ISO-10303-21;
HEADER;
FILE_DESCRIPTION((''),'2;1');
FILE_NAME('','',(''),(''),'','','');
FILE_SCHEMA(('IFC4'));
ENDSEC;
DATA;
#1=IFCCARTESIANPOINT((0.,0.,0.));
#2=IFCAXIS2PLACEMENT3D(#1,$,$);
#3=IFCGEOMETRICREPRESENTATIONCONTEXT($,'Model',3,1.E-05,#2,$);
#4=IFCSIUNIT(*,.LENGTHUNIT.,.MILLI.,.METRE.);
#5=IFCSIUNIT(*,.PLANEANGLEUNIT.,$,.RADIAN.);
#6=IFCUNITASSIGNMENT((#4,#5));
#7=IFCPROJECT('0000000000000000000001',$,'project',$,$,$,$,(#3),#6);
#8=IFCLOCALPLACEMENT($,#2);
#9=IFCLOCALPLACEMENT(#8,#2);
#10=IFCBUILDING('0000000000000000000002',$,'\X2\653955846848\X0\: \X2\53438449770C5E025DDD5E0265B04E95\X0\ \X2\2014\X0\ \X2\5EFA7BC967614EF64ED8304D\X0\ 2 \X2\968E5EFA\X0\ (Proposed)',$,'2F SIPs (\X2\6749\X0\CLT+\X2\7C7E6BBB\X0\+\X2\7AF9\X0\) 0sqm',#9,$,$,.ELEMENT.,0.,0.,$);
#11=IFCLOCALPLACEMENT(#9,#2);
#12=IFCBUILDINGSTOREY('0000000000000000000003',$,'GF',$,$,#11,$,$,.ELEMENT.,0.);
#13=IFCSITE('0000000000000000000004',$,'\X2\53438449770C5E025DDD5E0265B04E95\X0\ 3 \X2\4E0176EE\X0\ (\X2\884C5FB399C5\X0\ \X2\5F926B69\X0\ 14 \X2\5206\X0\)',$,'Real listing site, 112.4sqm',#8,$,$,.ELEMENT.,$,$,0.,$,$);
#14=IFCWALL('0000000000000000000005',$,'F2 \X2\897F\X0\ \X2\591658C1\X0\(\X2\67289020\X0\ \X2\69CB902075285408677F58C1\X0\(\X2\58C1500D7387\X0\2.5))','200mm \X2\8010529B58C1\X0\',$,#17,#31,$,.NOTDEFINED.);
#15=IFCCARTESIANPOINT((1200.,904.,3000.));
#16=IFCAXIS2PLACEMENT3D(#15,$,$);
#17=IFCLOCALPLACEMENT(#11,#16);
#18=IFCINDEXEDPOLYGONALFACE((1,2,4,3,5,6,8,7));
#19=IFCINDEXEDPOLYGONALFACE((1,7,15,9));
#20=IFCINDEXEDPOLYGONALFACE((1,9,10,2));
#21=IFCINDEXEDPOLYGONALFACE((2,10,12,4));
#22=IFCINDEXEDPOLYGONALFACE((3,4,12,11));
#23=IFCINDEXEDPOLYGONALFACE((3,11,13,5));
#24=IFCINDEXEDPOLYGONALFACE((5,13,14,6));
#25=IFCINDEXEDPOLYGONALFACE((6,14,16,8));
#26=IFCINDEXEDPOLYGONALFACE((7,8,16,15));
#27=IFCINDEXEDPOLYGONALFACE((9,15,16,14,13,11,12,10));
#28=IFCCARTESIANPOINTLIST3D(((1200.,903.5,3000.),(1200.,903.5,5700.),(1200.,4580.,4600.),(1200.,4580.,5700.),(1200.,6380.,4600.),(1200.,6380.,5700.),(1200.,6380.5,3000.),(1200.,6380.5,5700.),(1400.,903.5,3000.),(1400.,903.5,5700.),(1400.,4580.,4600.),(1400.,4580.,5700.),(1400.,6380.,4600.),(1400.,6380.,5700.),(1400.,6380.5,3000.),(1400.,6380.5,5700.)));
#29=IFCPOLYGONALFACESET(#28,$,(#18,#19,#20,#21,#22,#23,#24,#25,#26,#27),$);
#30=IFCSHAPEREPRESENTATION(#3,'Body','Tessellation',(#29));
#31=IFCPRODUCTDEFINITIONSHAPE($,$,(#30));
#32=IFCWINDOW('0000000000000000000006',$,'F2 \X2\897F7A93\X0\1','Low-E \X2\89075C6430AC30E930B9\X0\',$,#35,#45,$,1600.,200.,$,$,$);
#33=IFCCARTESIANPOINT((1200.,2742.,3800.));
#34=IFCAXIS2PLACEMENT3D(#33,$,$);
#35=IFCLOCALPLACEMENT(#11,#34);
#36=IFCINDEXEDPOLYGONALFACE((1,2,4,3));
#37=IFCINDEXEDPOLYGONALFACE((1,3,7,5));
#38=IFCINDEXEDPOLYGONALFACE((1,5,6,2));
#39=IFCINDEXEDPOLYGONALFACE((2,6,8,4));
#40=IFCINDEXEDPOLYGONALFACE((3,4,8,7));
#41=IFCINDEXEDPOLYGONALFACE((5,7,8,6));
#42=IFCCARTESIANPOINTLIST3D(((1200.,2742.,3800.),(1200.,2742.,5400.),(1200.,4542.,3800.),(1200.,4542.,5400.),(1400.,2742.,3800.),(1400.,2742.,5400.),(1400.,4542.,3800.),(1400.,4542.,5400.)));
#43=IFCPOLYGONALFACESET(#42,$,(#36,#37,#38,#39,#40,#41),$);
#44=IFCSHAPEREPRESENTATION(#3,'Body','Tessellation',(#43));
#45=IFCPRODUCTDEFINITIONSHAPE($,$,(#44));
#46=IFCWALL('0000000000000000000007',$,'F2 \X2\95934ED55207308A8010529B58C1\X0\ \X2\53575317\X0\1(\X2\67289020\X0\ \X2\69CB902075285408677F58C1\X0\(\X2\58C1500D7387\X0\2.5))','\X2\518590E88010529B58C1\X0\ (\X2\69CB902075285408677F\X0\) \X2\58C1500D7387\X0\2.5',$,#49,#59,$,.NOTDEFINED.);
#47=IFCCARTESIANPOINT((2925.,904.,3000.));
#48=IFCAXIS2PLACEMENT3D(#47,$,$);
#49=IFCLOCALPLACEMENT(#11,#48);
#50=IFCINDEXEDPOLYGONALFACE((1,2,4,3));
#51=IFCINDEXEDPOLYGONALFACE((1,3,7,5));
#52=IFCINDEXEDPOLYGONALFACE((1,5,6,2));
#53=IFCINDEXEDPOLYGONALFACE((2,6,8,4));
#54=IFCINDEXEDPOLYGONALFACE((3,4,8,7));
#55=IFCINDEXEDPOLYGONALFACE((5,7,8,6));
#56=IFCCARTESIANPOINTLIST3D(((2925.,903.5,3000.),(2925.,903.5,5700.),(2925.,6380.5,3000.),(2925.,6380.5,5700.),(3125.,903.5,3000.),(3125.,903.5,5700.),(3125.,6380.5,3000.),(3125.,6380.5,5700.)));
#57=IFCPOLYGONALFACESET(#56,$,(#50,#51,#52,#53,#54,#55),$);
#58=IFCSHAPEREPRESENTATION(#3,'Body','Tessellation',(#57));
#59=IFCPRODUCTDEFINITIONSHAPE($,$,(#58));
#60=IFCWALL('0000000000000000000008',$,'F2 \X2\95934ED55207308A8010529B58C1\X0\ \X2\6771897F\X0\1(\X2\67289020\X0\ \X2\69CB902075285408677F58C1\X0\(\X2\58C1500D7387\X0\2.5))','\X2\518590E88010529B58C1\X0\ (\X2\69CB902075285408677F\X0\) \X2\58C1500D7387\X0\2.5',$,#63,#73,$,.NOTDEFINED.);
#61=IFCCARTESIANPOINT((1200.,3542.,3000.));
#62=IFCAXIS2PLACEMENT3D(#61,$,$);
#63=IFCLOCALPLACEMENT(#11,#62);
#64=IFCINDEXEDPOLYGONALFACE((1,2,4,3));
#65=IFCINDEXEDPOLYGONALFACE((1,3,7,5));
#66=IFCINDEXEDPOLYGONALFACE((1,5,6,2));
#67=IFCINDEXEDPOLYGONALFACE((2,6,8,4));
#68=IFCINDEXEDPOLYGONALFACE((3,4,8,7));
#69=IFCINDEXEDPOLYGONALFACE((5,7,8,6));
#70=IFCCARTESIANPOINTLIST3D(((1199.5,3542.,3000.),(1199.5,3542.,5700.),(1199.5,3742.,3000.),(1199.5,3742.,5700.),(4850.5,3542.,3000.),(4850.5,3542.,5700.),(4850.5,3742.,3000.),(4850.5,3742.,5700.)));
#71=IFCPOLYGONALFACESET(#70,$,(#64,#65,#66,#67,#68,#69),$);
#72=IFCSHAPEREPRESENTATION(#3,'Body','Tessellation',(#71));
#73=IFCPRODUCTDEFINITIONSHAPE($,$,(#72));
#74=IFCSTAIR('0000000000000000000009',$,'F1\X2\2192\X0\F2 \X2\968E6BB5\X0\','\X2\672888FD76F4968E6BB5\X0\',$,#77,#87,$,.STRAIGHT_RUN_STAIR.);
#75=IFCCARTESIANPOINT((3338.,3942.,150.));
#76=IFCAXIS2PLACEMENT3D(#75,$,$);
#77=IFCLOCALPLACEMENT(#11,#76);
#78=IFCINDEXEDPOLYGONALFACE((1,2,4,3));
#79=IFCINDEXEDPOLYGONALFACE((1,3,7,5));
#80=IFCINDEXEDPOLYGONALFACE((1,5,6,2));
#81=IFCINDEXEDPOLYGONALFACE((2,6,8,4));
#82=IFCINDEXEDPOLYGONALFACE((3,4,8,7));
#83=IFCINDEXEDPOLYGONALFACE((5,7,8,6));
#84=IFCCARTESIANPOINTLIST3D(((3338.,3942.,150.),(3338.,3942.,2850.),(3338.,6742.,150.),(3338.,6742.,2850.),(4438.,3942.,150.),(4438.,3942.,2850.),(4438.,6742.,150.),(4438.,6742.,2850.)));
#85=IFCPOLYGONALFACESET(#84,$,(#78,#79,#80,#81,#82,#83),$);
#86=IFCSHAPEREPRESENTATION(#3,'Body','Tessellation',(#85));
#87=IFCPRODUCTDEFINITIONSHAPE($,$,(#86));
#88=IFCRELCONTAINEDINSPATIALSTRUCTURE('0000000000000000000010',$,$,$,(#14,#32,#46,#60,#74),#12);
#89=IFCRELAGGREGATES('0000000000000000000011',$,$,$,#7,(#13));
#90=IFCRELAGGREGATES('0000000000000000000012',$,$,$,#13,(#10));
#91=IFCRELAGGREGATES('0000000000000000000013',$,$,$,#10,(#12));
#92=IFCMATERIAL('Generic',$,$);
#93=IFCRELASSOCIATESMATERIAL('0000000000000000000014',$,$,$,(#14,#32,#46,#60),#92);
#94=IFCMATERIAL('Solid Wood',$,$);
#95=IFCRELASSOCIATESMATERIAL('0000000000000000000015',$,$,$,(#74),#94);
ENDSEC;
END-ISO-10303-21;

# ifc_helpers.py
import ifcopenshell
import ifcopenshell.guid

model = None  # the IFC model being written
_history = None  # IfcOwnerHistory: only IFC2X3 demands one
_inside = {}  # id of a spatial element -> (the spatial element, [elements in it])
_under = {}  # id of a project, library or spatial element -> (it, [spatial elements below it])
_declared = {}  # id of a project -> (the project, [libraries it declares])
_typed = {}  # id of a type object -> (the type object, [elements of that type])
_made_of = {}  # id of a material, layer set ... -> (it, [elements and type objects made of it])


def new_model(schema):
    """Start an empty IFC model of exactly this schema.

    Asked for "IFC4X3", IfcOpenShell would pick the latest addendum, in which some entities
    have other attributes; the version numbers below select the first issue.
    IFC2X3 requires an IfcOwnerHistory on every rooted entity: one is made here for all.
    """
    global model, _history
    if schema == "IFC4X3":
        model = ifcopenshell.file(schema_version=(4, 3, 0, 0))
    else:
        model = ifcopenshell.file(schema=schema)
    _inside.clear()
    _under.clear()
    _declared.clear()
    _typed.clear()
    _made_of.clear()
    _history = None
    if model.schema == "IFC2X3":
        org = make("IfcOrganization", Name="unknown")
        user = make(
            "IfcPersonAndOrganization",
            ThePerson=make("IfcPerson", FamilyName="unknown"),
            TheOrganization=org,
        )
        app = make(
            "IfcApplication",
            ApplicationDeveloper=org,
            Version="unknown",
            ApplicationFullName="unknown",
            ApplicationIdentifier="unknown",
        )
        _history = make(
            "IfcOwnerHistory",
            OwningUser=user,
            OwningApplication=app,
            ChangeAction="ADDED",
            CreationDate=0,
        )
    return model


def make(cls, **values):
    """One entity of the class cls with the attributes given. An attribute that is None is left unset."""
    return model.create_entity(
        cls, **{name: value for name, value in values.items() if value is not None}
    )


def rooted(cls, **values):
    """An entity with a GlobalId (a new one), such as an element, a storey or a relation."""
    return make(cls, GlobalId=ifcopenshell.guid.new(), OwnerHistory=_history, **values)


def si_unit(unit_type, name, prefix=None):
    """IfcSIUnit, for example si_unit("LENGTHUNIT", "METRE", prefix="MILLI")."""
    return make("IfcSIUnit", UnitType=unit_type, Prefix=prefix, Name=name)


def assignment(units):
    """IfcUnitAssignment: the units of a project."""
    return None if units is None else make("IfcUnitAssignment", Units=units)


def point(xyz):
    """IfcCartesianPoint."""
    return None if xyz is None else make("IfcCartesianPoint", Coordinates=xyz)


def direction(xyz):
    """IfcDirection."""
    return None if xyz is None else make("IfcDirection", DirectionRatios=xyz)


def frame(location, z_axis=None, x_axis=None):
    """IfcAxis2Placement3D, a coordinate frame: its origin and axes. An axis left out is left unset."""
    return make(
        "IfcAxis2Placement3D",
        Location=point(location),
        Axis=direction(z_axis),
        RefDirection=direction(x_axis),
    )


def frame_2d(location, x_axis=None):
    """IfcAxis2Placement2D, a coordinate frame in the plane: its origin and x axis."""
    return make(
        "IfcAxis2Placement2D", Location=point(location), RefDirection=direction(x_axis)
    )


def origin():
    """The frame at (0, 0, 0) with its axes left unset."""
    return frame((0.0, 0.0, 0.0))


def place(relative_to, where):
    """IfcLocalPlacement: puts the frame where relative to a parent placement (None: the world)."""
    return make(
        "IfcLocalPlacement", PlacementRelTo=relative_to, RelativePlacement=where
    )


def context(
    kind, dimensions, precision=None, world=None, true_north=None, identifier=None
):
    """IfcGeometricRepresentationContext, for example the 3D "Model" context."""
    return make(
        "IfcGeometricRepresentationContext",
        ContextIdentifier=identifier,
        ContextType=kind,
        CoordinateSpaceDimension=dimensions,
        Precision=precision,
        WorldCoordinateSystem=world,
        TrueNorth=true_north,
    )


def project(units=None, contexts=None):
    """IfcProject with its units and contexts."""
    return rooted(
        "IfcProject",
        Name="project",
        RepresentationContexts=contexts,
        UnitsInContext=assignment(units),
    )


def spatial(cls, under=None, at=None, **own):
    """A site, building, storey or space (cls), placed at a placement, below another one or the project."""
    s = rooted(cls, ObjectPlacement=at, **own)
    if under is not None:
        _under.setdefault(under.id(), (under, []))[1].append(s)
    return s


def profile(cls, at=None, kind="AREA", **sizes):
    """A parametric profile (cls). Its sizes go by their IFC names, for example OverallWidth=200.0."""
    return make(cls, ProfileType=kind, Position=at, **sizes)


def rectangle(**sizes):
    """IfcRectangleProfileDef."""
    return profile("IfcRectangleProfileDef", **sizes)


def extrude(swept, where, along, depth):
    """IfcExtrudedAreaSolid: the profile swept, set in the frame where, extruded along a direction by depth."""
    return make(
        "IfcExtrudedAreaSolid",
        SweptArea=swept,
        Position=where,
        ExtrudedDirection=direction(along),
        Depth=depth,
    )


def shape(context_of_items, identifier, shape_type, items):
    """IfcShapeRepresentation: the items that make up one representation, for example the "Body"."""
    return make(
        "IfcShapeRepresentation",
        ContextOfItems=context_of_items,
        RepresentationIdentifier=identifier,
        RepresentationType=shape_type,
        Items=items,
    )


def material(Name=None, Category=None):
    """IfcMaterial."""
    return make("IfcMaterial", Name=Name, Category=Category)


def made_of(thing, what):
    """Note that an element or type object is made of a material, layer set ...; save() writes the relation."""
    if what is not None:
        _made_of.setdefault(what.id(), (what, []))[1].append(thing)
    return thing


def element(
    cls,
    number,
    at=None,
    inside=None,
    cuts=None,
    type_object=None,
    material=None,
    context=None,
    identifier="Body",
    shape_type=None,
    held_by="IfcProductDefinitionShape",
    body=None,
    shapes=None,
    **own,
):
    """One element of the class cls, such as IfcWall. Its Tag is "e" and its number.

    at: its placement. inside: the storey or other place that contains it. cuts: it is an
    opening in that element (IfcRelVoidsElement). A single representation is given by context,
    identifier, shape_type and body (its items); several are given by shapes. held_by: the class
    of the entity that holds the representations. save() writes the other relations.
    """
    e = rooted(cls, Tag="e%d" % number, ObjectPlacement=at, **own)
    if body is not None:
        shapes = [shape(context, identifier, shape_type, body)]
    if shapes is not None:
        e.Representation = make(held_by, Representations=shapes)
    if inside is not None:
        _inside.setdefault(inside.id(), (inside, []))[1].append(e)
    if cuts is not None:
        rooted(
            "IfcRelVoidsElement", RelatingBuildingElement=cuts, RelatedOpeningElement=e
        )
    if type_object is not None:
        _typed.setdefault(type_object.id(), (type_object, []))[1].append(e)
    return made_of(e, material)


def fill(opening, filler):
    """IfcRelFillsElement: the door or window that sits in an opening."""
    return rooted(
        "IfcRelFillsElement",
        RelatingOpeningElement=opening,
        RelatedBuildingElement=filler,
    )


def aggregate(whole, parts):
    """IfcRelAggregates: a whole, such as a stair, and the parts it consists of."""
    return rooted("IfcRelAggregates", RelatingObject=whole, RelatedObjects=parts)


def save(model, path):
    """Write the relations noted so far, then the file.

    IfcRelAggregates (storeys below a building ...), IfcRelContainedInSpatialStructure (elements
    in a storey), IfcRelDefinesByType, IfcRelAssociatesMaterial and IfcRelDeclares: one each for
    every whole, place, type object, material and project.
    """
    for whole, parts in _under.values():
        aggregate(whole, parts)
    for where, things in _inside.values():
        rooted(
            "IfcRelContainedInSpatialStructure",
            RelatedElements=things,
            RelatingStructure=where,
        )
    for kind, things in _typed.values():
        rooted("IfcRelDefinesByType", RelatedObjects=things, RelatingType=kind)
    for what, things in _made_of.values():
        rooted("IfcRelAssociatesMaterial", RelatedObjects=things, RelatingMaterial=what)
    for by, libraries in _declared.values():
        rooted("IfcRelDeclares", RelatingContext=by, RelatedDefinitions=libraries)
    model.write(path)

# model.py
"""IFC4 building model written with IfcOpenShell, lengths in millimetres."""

from ifc_helpers import new_model, si_unit, frame, frame_2d, origin, place, context, project, spatial, rectangle, extrude, material, element, fill, save


model = new_model("IFC4")

# Units and contexts
model_context = context("Model", 3, precision=1e-05, world=origin())
ifc_project = project(units=[si_unit("LENGTHUNIT", "METRE", prefix="MILLI"), si_unit("PLANEANGLEUNIT", "RADIAN")], contexts=[model_context])

# Site, building, storey
site_placement = place(None, origin())
site = spatial("IfcSite", under=ifc_project, at=site_placement, Name="千葉県市川市新井 3 丁目 (行徳駅 徒歩 14 分)", ObjectType="Real listing site, 112.4sqm", CompositionType="ELEMENT", RefElevation=0.0)
building_placement = place(site_placement, origin())
building = spatial("IfcBuilding", under=site, at=building_placement, Name="改善案: 千葉県市川市新井 — 建築条件付き 2 階建 (Proposed)", ObjectType="2F SIPs (杉CLT+籾殻+竹) 0sqm", CompositionType="ELEMENT", ElevationOfRefHeight=0.0, ElevationOfTerrain=0.0)
storey_placement = place(building_placement, origin())
storey = spatial("IfcBuildingStorey", under=building, at=storey_placement, Name="GF", CompositionType="ELEMENT", Elevation=0.0)

# Shared definitions
ifc_material_1 = material(Name="Generic")

# Shared definitions
ifc_material_2 = material(Name="Solid Wood")

# Wall, opening, window
wall_1_placement = place(storey_placement, frame((1200.0, 904.0, 3000.0)))
wall_1 = element("IfcWall", 1, at=wall_1_placement, inside=storey, material=ifc_material_1, Name="F2 西 外壁(木造 構造用合板壁(壁倍率2.5))", Description="200mm 耐力壁", PredefinedType="NOTDEFINED", context=model_context, shape_type="SweptSolid", body=[
    extrude(rectangle(XDim=200.0, YDim=5477.0, at=frame_2d((100.0, 2738.0))), frame((1200.0, 904.0, 3000.0)), (0.0, 0.0, 1.0), 2700.0),
])
opening_1_placement = place(storey_placement, frame((1200.0, 2742.0, 3800.0)))
opening_1 = element("IfcOpeningElement", 2, at=opening_1_placement, cuts=wall_1, PredefinedType="NOTDEFINED", context=model_context, shape_type="SweptSolid", body=[
    extrude(rectangle(XDim=200.0, YDim=1800.0, at=frame_2d((100.0, 900.0))), frame((1200.0, 2742.0, 3800.0)), (0.0, 0.0, 1.0), 1600.0),
])
window_1_placement = place(storey_placement, frame((1200.0, 2742.0, 3800.0)))
window_1 = element("IfcWindow", 3, at=window_1_placement, inside=storey, material=ifc_material_1, Name="F2 西窓1", Description="Low-E 複層ガラス", OverallHeight=1600.0, OverallWidth=200.0, context=model_context, shape_type="SweptSolid", body=[
    extrude(rectangle(XDim=200.0, YDim=1800.0, at=frame_2d((100.0, 900.0))), frame((1200.0, 2742.0, 3800.0)), (0.0, 0.0, 1.0), 1600.0),
])
fill(opening_1, window_1)

# Walls
wall_2_placement = place(storey_placement, frame((2925.0, 904.0, 3000.0)))
element("IfcWall", 4, at=wall_2_placement, inside=storey, material=ifc_material_1, Name="F2 間仕切り耐力壁 南北1(木造 構造用合板壁(壁倍率2.5))", Description="内部耐力壁 (構造用合板) 壁倍率2.5", PredefinedType="NOTDEFINED", context=model_context, shape_type="SweptSolid", body=[
    extrude(rectangle(XDim=200.0, YDim=5477.0, at=frame_2d((100.0, 2738.0))), frame((2925.0, 904.0, 3000.0)), (0.0, 0.0, 1.0), 2700.0),
])
wall_3_placement = place(storey_placement, frame((1200.0, 3542.0, 3000.0)))
element("IfcWall", 5, at=wall_3_placement, inside=storey, material=ifc_material_1, Name="F2 間仕切り耐力壁 東西1(木造 構造用合板壁(壁倍率2.5))", Description="内部耐力壁 (構造用合板) 壁倍率2.5", PredefinedType="NOTDEFINED", context=model_context, shape_type="SweptSolid", body=[
    extrude(rectangle(XDim=3651.0, YDim=200.0, at=frame_2d((1825.0, 100.0))), frame((1200.0, 3542.0, 3000.0)), (0.0, 0.0, 1.0), 2700.0),
])

# Stair
stair_placement = place(storey_placement, frame((3338.0, 3942.0, 150.0)))
element("IfcStair", 6, at=stair_placement, inside=storey, material=ifc_material_2, Name="F1→F2 階段", Description="木製直階段", PredefinedType="STRAIGHT_RUN_STAIR", context=model_context, shape_type="SweptSolid", body=[
    extrude(rectangle(XDim=1100.0, YDim=2800.0, at=frame_2d((550.0, 1400.0))), frame((3338.0, 3942.0, 150.0)), (0.0, 0.0, 1.0), 2700.0),
])

save(model, "model.ifc")
